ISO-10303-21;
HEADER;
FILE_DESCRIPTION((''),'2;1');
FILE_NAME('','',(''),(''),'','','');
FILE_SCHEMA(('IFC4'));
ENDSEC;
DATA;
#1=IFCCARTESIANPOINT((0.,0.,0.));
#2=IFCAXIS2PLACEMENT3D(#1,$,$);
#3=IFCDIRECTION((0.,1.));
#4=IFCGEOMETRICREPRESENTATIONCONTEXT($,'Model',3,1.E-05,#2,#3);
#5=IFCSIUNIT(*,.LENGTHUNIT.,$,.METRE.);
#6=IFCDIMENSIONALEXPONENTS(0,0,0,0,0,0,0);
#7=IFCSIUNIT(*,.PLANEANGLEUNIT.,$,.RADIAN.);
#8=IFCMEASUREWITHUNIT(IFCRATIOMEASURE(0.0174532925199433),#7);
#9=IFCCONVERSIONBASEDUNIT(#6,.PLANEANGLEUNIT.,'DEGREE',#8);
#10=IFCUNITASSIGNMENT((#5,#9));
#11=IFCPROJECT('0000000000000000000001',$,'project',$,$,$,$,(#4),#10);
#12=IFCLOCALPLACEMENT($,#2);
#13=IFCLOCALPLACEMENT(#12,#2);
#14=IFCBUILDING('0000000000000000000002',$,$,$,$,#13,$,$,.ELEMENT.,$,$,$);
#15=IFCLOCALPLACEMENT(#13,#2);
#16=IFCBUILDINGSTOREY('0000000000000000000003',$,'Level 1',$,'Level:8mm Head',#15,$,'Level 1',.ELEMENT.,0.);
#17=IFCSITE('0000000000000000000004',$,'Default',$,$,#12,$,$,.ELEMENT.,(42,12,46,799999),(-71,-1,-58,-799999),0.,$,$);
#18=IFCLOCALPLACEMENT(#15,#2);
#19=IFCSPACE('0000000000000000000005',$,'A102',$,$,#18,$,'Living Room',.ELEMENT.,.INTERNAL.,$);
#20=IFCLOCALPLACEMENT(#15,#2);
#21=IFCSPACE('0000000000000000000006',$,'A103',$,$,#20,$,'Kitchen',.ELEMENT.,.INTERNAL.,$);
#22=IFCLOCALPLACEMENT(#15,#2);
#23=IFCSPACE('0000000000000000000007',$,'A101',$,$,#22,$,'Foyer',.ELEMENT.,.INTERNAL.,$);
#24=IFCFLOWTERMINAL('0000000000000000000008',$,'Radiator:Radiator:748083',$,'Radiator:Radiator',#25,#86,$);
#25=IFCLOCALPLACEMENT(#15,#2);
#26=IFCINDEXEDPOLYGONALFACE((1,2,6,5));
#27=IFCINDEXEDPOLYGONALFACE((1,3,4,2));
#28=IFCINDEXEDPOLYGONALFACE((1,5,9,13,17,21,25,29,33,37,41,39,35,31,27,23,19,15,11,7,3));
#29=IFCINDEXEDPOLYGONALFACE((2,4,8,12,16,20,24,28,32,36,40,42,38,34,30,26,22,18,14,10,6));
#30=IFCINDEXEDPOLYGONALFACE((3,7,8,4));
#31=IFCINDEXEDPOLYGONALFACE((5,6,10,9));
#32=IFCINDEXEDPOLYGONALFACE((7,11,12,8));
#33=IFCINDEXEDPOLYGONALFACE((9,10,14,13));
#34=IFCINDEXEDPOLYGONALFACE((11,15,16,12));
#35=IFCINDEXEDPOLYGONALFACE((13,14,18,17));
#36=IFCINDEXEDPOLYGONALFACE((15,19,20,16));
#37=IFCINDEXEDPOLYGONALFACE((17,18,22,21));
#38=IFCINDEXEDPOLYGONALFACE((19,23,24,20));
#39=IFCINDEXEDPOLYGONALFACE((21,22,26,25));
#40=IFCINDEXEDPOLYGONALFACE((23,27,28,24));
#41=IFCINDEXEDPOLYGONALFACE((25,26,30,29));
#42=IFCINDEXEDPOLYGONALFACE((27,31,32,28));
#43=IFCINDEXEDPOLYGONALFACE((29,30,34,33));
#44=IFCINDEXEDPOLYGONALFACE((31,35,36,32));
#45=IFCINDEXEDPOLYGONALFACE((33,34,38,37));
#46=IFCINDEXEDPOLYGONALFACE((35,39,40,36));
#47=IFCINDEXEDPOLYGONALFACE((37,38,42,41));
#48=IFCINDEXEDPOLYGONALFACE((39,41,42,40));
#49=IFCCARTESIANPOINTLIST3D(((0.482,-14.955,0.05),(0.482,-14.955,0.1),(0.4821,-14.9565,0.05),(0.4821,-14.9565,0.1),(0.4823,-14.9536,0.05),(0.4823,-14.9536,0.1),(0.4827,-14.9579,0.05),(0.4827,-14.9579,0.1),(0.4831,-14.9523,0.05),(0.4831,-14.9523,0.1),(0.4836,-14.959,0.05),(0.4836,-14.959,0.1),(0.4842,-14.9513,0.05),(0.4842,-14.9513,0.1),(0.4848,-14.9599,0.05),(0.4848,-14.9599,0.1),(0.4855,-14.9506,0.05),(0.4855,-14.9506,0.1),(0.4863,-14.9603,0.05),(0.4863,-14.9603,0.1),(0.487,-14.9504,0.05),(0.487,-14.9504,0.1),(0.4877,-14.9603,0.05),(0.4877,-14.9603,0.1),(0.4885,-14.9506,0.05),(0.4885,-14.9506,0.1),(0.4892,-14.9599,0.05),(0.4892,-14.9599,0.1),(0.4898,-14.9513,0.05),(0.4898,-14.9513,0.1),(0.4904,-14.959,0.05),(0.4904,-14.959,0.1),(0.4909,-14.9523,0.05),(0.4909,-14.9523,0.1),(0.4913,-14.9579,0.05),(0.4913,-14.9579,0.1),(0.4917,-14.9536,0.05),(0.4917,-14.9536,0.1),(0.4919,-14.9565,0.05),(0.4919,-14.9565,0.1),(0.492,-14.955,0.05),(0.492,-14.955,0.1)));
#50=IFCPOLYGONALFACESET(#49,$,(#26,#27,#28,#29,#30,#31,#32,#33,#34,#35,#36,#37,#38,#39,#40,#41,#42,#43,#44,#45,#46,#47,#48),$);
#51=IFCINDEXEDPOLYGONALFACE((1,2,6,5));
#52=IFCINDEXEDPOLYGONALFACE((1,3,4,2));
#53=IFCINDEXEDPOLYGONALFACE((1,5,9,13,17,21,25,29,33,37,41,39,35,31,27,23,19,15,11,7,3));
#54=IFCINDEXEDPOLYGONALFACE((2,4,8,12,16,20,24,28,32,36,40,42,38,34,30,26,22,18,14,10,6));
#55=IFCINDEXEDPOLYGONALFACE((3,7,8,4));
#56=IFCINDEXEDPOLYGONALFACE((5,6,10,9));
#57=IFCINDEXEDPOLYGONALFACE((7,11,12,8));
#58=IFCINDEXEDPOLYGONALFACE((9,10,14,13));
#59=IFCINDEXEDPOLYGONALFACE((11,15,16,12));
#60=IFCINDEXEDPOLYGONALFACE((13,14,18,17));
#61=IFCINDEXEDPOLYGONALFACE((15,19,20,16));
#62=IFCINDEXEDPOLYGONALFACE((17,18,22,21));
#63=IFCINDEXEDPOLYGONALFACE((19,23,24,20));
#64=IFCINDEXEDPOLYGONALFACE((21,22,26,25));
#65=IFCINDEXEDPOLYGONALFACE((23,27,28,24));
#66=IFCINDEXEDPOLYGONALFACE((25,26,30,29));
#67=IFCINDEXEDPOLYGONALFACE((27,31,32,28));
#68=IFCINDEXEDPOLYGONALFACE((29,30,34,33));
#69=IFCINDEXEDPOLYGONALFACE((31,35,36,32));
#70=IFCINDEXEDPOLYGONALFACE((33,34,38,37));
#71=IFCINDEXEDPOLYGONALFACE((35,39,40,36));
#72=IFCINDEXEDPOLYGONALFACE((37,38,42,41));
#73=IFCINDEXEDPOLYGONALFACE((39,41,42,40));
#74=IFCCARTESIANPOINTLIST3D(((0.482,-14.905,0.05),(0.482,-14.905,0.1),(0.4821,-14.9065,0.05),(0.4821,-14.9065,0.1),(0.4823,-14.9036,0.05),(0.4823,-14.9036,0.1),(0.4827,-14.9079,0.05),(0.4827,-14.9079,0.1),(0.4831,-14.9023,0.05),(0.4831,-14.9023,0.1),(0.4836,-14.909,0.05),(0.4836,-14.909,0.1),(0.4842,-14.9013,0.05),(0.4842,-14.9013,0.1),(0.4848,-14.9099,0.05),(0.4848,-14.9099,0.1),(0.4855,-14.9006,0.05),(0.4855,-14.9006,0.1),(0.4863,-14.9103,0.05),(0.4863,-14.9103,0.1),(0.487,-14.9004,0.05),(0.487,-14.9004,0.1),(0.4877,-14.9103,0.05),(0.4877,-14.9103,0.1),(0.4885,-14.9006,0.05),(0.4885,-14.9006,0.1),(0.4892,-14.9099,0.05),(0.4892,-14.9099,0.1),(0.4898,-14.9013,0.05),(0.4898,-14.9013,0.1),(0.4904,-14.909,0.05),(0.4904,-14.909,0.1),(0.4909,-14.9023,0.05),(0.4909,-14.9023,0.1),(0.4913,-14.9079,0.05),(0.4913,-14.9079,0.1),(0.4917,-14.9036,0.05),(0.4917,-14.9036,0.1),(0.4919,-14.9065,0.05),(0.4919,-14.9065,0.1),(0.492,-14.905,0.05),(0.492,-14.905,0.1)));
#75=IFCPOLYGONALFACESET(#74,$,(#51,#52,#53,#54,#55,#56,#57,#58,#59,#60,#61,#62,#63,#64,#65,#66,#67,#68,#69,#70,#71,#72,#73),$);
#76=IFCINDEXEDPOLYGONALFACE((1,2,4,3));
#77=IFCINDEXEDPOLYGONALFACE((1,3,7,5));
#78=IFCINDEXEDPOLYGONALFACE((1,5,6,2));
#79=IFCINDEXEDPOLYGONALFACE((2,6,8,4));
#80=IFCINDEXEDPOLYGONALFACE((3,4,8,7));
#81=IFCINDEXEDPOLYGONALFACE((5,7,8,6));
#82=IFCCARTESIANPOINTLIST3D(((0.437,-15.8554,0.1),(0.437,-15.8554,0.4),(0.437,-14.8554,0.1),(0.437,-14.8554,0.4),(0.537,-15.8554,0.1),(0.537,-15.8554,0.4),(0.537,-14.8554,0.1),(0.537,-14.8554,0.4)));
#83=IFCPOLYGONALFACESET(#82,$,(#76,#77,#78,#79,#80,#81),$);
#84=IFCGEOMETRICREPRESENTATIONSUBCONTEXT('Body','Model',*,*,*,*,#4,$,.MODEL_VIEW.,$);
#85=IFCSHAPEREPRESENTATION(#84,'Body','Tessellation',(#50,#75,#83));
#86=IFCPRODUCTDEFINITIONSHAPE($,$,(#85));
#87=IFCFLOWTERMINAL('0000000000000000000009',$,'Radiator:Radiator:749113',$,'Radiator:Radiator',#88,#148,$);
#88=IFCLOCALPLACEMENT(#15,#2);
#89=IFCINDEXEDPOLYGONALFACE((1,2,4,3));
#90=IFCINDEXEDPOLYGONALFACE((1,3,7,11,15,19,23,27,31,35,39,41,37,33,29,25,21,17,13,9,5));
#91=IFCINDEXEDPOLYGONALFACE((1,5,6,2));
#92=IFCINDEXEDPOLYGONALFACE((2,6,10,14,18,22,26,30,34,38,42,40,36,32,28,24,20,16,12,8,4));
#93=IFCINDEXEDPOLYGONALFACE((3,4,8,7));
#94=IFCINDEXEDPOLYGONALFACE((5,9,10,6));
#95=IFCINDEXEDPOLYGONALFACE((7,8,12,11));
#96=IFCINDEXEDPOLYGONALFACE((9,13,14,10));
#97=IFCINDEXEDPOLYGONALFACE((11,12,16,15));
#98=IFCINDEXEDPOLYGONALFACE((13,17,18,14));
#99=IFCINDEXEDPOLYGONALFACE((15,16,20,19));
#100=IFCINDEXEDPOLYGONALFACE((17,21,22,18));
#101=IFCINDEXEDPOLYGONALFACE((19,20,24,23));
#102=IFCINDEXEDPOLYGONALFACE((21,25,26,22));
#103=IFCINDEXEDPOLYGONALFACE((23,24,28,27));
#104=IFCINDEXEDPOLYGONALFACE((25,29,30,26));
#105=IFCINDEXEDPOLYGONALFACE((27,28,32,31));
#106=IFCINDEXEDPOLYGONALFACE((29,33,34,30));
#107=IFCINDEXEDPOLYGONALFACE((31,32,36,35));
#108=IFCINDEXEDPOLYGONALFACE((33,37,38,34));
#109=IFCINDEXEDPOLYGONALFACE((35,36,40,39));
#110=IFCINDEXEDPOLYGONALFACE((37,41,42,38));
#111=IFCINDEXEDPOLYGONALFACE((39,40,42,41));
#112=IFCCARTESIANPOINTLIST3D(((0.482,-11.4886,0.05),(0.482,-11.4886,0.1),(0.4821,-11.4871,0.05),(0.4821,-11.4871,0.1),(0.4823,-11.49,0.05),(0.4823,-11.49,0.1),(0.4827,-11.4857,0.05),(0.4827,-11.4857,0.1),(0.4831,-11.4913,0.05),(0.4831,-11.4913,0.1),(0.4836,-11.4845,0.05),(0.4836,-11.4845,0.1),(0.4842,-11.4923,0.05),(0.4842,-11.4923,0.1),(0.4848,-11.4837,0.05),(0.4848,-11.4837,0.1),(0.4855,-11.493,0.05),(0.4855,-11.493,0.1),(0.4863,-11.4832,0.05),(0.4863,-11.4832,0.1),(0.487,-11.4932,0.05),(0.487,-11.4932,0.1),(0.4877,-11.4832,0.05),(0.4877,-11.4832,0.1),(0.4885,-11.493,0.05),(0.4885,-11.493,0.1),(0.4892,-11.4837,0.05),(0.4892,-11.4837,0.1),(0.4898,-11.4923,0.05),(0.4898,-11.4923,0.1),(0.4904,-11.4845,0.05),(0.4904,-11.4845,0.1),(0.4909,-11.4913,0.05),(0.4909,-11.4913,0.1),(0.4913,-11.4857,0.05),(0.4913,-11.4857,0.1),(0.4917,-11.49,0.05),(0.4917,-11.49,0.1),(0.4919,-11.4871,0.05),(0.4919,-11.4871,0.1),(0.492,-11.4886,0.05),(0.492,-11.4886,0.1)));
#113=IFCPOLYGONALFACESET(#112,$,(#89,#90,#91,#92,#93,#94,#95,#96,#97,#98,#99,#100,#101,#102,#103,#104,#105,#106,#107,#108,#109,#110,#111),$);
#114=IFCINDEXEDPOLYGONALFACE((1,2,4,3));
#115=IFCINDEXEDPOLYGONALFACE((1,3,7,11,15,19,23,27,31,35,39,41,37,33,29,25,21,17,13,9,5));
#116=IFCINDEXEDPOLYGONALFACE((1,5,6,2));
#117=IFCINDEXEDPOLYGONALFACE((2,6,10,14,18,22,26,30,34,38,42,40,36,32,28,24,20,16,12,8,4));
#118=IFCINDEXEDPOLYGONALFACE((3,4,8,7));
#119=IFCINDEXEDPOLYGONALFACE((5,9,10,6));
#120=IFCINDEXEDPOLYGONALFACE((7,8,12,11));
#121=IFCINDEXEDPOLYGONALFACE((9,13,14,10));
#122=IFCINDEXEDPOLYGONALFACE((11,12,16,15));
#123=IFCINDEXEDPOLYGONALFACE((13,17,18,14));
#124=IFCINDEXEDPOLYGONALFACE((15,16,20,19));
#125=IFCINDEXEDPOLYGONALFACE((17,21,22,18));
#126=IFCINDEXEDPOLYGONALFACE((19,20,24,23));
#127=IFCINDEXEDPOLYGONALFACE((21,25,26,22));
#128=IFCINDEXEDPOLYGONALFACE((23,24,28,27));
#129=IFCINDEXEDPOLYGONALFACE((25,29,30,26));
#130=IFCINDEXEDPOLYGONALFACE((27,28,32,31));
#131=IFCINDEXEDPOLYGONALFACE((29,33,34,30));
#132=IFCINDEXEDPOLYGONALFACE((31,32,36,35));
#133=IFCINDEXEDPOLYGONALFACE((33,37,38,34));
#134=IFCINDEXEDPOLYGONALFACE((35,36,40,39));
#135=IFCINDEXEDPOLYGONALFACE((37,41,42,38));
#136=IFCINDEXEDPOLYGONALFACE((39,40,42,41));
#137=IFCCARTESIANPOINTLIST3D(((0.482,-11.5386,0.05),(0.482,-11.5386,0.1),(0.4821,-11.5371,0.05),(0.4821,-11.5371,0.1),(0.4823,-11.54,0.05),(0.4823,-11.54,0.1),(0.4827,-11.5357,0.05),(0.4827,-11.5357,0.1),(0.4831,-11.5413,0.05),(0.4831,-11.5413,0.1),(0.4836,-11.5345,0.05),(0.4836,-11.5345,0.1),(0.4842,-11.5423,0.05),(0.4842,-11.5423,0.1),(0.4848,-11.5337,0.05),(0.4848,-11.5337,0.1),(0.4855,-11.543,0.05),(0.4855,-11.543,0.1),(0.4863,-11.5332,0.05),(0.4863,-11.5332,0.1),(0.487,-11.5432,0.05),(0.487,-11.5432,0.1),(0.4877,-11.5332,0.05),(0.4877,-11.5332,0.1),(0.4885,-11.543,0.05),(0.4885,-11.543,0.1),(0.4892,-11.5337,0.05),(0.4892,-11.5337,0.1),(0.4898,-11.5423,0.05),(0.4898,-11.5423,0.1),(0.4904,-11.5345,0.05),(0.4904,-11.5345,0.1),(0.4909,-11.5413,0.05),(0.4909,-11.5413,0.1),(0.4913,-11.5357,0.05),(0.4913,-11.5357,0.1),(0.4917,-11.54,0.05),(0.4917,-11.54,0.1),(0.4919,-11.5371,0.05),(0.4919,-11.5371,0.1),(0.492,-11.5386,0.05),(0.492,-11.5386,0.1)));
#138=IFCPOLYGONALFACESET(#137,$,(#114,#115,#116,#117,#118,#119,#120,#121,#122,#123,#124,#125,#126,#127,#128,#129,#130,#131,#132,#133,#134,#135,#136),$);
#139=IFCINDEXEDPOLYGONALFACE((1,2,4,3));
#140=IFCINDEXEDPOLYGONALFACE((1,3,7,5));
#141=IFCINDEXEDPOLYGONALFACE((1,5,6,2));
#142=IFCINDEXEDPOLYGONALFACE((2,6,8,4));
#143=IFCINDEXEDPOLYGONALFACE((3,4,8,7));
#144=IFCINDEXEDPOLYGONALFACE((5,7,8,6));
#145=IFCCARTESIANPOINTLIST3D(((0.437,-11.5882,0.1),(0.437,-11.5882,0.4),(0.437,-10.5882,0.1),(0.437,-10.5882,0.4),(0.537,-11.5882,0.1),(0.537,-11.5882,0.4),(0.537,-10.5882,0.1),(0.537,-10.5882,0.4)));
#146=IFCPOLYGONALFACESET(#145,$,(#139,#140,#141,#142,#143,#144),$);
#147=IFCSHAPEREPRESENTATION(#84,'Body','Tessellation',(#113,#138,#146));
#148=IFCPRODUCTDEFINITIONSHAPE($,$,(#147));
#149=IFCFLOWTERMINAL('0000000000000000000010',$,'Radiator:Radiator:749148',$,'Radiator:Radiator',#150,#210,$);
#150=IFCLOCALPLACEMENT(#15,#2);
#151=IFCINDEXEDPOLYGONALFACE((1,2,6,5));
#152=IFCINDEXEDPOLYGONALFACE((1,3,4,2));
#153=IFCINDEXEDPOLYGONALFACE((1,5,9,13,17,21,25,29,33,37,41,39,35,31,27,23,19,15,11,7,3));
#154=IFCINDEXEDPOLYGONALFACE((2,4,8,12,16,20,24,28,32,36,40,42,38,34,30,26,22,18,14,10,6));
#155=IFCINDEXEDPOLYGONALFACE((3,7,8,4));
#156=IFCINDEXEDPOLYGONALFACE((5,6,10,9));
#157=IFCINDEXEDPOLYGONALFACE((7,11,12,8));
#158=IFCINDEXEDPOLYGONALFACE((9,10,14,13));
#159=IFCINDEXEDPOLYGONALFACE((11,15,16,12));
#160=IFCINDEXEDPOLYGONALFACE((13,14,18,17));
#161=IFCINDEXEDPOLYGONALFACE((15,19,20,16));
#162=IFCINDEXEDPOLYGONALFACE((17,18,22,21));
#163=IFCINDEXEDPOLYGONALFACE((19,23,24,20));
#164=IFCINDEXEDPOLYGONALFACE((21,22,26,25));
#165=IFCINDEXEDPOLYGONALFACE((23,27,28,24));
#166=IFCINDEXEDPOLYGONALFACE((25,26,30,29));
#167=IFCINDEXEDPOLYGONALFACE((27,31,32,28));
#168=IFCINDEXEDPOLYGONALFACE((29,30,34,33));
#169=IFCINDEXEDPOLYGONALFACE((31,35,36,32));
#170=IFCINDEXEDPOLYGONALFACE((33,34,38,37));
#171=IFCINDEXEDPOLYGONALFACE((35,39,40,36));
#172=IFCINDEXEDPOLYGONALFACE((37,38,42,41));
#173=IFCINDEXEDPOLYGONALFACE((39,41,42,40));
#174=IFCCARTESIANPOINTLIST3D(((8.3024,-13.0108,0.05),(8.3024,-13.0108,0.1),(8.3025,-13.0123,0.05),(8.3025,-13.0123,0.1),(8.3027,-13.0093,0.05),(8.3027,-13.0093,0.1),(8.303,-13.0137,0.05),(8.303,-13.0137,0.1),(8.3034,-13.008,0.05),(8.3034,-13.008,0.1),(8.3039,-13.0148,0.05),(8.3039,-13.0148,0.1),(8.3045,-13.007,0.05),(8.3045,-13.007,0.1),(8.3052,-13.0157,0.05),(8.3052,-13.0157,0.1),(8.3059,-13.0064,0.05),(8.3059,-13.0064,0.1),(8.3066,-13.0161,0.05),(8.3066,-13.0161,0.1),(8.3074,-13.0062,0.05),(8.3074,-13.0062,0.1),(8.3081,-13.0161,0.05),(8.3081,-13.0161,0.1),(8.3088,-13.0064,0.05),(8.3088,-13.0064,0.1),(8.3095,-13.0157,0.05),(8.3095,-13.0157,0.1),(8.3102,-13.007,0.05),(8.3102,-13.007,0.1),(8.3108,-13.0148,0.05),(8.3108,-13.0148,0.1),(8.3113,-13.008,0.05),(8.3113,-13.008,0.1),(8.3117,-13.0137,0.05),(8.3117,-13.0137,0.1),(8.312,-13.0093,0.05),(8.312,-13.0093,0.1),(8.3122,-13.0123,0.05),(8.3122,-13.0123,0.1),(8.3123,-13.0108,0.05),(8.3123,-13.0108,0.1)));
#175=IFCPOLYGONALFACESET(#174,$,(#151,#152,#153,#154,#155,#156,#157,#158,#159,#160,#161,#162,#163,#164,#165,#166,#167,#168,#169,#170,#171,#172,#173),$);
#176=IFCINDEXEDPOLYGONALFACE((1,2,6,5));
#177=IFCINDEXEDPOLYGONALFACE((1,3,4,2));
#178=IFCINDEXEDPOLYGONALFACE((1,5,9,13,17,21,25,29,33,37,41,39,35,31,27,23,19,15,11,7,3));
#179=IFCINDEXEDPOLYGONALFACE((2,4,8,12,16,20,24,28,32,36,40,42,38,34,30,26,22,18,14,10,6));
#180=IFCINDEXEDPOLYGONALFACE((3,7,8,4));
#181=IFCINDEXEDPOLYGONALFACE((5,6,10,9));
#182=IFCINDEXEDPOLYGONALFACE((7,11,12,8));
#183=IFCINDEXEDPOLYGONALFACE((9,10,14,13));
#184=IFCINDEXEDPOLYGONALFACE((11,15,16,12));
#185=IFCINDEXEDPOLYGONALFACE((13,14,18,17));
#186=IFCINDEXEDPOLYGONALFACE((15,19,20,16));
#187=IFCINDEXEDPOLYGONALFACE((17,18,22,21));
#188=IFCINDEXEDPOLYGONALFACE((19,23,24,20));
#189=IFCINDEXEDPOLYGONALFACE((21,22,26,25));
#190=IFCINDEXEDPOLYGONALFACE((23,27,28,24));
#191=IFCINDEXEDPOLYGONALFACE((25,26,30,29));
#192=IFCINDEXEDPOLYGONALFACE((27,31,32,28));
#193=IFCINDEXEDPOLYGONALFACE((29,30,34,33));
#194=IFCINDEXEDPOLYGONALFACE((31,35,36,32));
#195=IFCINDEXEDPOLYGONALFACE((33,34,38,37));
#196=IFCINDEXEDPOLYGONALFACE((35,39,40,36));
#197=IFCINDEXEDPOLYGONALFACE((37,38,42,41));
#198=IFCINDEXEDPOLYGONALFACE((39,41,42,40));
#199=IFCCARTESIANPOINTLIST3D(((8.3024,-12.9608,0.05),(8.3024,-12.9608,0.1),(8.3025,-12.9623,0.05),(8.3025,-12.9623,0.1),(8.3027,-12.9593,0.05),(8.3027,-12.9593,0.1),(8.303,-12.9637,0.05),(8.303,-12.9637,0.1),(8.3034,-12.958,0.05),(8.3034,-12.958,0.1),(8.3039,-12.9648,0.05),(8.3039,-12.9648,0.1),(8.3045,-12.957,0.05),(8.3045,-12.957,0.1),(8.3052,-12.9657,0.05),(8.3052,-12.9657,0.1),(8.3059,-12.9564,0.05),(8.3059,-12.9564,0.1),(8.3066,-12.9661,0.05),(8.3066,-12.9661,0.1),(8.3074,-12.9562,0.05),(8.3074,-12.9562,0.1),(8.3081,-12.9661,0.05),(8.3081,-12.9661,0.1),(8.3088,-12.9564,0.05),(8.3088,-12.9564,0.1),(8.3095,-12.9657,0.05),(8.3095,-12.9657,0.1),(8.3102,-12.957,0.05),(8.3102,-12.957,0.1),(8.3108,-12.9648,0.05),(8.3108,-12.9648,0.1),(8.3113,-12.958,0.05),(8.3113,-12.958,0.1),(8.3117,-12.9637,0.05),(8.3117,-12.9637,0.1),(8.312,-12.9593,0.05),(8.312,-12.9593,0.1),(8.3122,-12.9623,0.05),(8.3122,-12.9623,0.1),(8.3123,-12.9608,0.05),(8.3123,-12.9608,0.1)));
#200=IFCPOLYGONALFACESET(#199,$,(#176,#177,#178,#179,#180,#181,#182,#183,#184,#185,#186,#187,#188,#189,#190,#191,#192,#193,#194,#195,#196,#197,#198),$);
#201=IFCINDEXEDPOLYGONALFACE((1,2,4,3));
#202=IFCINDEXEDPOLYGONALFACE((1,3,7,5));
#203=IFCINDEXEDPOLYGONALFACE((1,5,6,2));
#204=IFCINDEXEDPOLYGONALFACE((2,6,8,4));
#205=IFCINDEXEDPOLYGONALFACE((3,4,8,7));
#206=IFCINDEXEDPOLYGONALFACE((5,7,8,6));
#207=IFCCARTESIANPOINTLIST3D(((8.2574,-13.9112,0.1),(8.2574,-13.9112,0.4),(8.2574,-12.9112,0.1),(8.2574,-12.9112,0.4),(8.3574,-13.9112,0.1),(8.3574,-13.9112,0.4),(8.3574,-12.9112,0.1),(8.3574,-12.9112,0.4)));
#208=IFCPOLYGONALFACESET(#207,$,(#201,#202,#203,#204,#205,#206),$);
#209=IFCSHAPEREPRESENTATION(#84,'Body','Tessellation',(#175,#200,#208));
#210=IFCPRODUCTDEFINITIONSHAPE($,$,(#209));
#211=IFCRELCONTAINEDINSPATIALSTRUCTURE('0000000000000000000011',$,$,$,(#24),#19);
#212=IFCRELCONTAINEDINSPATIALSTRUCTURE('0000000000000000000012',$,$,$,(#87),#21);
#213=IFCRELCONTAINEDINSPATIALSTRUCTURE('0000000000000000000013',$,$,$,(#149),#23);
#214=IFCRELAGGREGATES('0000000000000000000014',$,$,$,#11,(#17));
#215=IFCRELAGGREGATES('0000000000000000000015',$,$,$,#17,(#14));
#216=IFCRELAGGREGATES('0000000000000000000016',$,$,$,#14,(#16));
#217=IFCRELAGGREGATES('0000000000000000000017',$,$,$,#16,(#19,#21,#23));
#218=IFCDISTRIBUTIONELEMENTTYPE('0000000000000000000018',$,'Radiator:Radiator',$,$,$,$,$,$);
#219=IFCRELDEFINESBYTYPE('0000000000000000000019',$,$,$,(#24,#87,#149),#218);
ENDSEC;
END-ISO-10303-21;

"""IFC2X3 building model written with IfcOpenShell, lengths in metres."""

from ifc_helpers import new_model, entity, si_unit, converted_unit, direction, frame, frame_2d, origin, origin_2d_with_axis, place, context, subcontext, project, spatial, rectangle, circle, extrude, source, transform, mapped, type_object, type_shapes, element, save


model = new_model("IFC2X3")

# Units and contexts
model_context = context("Model", 3, precision=1e-05, world=origin(), true_north=direction((0.0, 1.0)))
body_context = subcontext(model_context, "Body", "Model", "MODEL_VIEW")
ifc_project = project(units=[si_unit("LENGTHUNIT", "METRE"), converted_unit("PLANEANGLEUNIT", "DEGREE", entity("IfcRatioMeasure", 0.0174532925199433), si_unit("PLANEANGLEUNIT", "RADIAN"), dimensions=[0, 0, 0, 0, 0, 0, 0])], contexts=[model_context])

# Site, building, storey, space
site_placement = place(None, origin())
site = spatial("IfcSite", under=ifc_project, at=site_placement, Name="Default", CompositionType="ELEMENT", RefLatitude=(42, 12, 46, 799999), RefLongitude=(-71, -1, -58, -799999), RefElevation=0.0)
building_placement = place(site_placement, origin())
building = spatial("IfcBuilding", under=site, at=building_placement, CompositionType="ELEMENT")
storey_placement = place(building_placement, origin())
storey = spatial("IfcBuildingStorey", under=building, at=storey_placement, Name="Level 1", ObjectType="Level:8mm Head", LongName="Level 1", CompositionType="ELEMENT", Elevation=0.0)
space_1_placement = place(storey_placement, origin())
space_1 = spatial("IfcSpace", under=storey, at=space_1_placement, Name="A102", LongName="Living Room", CompositionType="ELEMENT", InteriorOrExteriorSpace="INTERNAL")

# Flow terminal
distribution_element_type_1 = type_object("IfcDistributionElementType", Name="Radiator:Radiator")
shared_shape_1 = source(origin(), body_context, "Body", "SweptSolid", [
    extrude(circle(Radius=0.005, at=frame_2d((0.0, 0.0), x_axis=(1.0, 0.0))), frame((0.4, 0.0, -0.05)), (0.0, 0.0, 1.0), 0.05),
    extrude(circle(Radius=0.005, at=frame_2d((0.0, 0.0), x_axis=(1.0, 0.0))), frame((0.45, 0.0, -0.05)), (0.0, 0.0, 1.0), 0.05),
    extrude(rectangle(XDim=1.0, YDim=0.1, at=origin_2d_with_axis()), frame((0.0, 0.0, 0.0), z_axis=(0.0, 0.0, 1.0), x_axis=(-1.0, 0.0, 0.0)), (0.0, 0.0, 1.0), 0.3),
])
type_shapes(distribution_element_type_1, [shared_shape_1])
flow_terminal_1_placement = place(space_1_placement, frame((0.487, -15.3554, 0.1), z_axis=(0.0, 0.0, 1.0), x_axis=(0.0, 1.0, 0.0)))
element("IfcFlowTerminal", 1, at=flow_terminal_1_placement, inside=space_1, type_object=distribution_element_type_1, Name="Radiator:Radiator:748083", ObjectType="Radiator:Radiator", context=body_context, shape_type="MappedRepresentation", body=[
    mapped(shared_shape_1, transform((0.0, 0.0, 0.0), scale=1.0)),
])

# Shared definitions
space_2_placement = place(storey_placement, origin())
space_2 = spatial("IfcSpace", under=storey, at=space_2_placement, Name="A103", LongName="Kitchen", CompositionType="ELEMENT", InteriorOrExteriorSpace="INTERNAL")

# Flow terminal
flow_terminal_2_placement = place(space_2_placement, frame((0.487, -11.0882, 0.1), z_axis=(0.0, 0.0, 1.0), x_axis=(0.0, -1.0, 0.0)))
element("IfcFlowTerminal", 2, at=flow_terminal_2_placement, inside=space_2, type_object=distribution_element_type_1, Name="Radiator:Radiator:749113", ObjectType="Radiator:Radiator", context=body_context, shape_type="MappedRepresentation", body=[
    mapped(shared_shape_1, transform((0.0, 0.0, 0.0), scale=1.0)),
])

# Shared definitions
space_3_placement = place(storey_placement, origin())
space_3 = spatial("IfcSpace", under=storey, at=space_3_placement, Name="A101", LongName="Foyer", CompositionType="ELEMENT", InteriorOrExteriorSpace="INTERNAL")

# Flow terminal
flow_terminal_3_placement = place(space_3_placement, frame((8.3074, -13.4112, 0.1), z_axis=(0.0, 0.0, 1.0), x_axis=(0.0, 1.0, 0.0)))
element("IfcFlowTerminal", 3, at=flow_terminal_3_placement, inside=space_3, type_object=distribution_element_type_1, Name="Radiator:Radiator:749148", ObjectType="Radiator:Radiator", context=body_context, shape_type="MappedRepresentation", body=[
    mapped(shared_shape_1, transform((0.0, 0.0, 0.0), scale=1.0)),
])

save(model, "model.ifc")
